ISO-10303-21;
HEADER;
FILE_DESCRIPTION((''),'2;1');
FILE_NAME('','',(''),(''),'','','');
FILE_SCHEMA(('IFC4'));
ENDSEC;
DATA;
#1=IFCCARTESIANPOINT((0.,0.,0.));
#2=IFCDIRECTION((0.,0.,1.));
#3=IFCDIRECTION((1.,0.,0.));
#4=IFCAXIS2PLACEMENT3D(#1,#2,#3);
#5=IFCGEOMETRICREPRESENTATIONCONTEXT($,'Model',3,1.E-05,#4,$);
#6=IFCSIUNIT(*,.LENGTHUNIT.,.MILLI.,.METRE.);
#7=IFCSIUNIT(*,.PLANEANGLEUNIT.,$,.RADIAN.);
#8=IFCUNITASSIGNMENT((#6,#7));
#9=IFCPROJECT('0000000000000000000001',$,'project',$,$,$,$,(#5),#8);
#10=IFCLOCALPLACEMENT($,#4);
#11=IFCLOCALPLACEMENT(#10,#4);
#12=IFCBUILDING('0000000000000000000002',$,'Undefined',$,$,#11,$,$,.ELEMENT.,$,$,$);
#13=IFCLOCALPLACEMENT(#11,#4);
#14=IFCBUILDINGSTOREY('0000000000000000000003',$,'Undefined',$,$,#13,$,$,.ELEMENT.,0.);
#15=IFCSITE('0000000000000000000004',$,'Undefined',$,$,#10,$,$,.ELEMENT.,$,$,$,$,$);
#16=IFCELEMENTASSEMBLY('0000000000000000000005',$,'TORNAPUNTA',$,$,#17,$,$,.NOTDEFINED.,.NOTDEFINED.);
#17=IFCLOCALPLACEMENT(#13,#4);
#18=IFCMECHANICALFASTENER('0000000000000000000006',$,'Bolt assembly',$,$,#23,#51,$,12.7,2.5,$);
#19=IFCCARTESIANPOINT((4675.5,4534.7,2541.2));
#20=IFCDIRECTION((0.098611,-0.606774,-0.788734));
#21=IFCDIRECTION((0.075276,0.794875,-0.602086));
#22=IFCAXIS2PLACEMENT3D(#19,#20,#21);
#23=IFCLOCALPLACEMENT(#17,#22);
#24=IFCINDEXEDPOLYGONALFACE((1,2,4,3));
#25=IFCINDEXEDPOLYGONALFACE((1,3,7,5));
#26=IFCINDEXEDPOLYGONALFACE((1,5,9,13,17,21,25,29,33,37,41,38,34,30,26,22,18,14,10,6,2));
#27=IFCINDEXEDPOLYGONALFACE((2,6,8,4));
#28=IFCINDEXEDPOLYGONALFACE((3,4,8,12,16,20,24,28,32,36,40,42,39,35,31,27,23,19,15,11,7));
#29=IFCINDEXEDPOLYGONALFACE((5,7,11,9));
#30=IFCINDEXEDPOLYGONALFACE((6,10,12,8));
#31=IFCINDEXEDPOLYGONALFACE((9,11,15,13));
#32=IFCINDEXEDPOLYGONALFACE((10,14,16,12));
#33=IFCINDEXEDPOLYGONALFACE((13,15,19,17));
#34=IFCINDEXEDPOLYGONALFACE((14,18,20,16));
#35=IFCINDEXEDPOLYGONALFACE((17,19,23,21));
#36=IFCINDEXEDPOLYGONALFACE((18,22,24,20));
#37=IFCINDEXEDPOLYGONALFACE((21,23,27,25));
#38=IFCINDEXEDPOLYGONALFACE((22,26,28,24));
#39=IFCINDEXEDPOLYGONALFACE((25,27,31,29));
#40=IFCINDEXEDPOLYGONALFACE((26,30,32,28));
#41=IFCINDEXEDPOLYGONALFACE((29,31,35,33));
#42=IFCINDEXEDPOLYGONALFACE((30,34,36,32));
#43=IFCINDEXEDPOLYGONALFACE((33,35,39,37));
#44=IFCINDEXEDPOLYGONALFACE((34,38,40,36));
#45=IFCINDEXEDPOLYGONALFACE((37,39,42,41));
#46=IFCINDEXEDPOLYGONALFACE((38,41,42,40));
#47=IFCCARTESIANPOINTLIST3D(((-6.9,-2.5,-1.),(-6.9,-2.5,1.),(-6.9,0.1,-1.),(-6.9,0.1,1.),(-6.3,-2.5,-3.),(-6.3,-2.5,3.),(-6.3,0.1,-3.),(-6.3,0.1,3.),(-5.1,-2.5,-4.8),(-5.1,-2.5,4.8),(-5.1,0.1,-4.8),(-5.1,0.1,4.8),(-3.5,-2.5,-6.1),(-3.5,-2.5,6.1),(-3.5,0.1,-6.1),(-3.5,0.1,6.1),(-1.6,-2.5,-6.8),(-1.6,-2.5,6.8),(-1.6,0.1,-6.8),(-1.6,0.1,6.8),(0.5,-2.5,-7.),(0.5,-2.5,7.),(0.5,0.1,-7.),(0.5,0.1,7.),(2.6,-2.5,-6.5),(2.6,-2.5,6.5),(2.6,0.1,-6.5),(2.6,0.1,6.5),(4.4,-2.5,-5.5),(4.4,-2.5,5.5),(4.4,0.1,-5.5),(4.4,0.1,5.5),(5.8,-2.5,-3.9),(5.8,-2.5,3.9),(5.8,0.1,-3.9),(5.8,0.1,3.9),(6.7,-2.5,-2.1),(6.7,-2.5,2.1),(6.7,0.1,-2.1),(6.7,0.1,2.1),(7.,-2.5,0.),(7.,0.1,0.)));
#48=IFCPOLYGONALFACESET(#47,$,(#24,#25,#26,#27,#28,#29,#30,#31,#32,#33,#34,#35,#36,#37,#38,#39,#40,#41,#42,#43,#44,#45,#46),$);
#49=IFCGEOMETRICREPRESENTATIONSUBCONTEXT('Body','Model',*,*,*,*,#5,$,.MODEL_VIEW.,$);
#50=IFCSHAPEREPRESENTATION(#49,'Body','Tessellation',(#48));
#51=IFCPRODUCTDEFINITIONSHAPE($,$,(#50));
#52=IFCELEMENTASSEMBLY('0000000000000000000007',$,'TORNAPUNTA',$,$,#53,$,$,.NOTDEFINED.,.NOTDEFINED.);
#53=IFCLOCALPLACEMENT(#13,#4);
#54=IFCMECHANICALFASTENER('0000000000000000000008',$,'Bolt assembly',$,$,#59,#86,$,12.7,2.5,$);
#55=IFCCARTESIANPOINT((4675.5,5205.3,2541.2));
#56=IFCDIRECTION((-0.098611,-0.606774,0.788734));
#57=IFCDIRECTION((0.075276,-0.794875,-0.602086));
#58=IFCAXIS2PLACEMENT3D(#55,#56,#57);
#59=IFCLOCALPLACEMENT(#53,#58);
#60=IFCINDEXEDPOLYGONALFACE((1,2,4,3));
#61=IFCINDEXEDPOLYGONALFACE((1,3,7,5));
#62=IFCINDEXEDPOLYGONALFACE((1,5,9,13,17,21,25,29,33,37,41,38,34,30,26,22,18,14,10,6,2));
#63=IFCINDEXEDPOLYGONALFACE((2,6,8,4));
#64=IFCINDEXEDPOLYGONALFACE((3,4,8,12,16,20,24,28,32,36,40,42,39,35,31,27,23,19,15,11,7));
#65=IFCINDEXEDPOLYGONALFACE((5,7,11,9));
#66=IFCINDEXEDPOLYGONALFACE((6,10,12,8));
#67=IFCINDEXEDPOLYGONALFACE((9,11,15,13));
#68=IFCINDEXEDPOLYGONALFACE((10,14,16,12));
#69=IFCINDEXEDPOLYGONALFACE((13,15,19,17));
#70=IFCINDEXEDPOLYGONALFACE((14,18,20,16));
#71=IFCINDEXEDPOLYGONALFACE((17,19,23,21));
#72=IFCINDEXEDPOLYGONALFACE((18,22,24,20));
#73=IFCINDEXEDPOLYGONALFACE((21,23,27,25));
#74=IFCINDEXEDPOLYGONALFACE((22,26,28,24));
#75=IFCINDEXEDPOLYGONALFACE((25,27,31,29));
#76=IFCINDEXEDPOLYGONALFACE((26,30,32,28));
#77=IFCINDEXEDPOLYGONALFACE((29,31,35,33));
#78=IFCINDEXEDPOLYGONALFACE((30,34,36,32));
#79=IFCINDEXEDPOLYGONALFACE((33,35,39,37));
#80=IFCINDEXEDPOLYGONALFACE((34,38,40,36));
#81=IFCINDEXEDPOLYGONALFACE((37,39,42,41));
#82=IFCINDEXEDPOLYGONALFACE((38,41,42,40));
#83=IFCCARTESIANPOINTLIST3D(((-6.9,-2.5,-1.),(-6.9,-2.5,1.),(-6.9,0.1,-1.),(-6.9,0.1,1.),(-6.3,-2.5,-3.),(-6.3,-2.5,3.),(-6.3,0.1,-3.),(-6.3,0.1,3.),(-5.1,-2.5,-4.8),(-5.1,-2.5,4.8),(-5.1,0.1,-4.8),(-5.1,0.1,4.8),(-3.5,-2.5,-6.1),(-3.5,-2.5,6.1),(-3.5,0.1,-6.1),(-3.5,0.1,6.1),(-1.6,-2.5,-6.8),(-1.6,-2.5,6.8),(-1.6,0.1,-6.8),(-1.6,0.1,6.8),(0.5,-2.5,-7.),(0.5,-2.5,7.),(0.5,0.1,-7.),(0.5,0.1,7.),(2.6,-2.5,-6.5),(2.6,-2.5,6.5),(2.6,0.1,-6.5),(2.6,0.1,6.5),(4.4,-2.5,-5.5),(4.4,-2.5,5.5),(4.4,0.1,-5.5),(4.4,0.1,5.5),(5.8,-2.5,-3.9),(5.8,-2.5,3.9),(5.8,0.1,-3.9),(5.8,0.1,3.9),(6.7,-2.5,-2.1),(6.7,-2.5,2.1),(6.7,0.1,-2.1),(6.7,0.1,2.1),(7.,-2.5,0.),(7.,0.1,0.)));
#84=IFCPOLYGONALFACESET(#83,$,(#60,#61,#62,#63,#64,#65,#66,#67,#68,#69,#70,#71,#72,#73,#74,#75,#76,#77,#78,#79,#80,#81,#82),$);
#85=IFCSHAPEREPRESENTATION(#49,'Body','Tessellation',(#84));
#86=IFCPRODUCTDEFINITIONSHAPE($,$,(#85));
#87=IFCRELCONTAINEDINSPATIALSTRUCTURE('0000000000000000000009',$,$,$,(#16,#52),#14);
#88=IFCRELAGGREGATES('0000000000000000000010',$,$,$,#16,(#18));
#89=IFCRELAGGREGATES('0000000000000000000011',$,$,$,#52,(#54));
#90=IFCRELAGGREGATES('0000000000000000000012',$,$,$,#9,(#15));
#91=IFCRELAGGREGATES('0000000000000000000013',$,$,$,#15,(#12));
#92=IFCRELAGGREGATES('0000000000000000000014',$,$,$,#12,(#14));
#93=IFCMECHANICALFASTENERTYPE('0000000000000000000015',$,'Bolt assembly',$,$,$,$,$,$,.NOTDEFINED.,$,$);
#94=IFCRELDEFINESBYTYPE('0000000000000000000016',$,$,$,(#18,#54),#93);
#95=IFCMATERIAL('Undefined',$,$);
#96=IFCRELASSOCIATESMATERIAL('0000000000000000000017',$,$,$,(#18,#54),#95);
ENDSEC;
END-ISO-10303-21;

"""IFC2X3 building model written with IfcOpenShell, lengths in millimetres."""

from ifc_helpers import new_model, si_unit, frame, origin_with_axes, origin_2d_with_axis, place, context, subcontext, project, spatial, circle, extrude, source, transform, mapped, material, type_object, element, aggregate, save


model = new_model("IFC2X3")

# Units and contexts
model_context = context("Model", 3, precision=1e-05, world=origin_with_axes())
body_context = subcontext(model_context, "Body", "Model", "MODEL_VIEW")
ifc_project = project(units=[si_unit("LENGTHUNIT", "METRE", prefix="MILLI"), si_unit("PLANEANGLEUNIT", "RADIAN")], contexts=[model_context])

# Site, building, storey
site_placement = place(None, origin_with_axes())
site = spatial("IfcSite", under=ifc_project, at=site_placement, Name="Undefined", CompositionType="ELEMENT")
building_placement = place(site_placement, origin_with_axes())
building = spatial("IfcBuilding", under=site, at=building_placement, Name="Undefined", CompositionType="ELEMENT")
storey_placement = place(building_placement, origin_with_axes())
storey = spatial("IfcBuildingStorey", under=building, at=storey_placement, Name="Undefined", CompositionType="ELEMENT", Elevation=0.0)

# Shared definitions
ifc_material_1 = material(Name="Undefined")
mechanical_fastener_type = type_object("IfcMechanicalFastenerType", Name="Bolt assembly")

# Element assemblies, mechanical fasteners
assembly_1_placement = place(storey_placement, origin_with_axes())
assembly_1 = element("IfcElementAssembly", 1, at=assembly_1_placement, inside=storey, Name="TORNAPUNTA", AssemblyPlace="NOTDEFINED", PredefinedType="NOTDEFINED")
shared_shape_1 = source(origin_with_axes(), body_context, "Body", "SweptSolid", [
    extrude(circle(Radius=7.0, at=origin_2d_with_axis()), frame((0.0, -2.5, 0.0), z_axis=(0.0, 1.0, 0.0), x_axis=(1.0, 0.0, 0.0)), (0.0, 0.0, 1.0), 2.6),
])
mechanical_fastener_1_placement = place(assembly_1_placement, frame((4675.5, 4534.7, 2541.2), z_axis=(0.098611, -0.606774, -0.788734), x_axis=(0.075276, 0.794875, -0.602086)))
mechanical_fastener_1 = element("IfcMechanicalFastener", 2, at=mechanical_fastener_1_placement, type_object=mechanical_fastener_type, material=ifc_material_1, Name="Bolt assembly", NominalDiameter=12.7, NominalLength=2.5, context=body_context, shape_type="MappedRepresentation", body=[
    mapped(shared_shape_1, transform((0.0, 0.0, 0.0))),
])
aggregate(assembly_1, [mechanical_fastener_1])
assembly_2_placement = place(storey_placement, origin_with_axes())
assembly_2 = element("IfcElementAssembly", 3, at=assembly_2_placement, inside=storey, Name="TORNAPUNTA", AssemblyPlace="NOTDEFINED", PredefinedType="NOTDEFINED")
mechanical_fastener_2_placement = place(assembly_2_placement, frame((4675.5, 5205.3, 2541.2), z_axis=(-0.098611, -0.606774, 0.788734), x_axis=(0.075276, -0.794875, -0.602086)))
mechanical_fastener_2 = element("IfcMechanicalFastener", 4, at=mechanical_fastener_2_placement, type_object=mechanical_fastener_type, material=ifc_material_1, Name="Bolt assembly", NominalDiameter=12.7, NominalLength=2.5, context=body_context, shape_type="MappedRepresentation", body=[
    mapped(shared_shape_1, transform((0.0, 0.0, 0.0))),
])
aggregate(assembly_2, [mechanical_fastener_2])

save(model, "model.ifc")
